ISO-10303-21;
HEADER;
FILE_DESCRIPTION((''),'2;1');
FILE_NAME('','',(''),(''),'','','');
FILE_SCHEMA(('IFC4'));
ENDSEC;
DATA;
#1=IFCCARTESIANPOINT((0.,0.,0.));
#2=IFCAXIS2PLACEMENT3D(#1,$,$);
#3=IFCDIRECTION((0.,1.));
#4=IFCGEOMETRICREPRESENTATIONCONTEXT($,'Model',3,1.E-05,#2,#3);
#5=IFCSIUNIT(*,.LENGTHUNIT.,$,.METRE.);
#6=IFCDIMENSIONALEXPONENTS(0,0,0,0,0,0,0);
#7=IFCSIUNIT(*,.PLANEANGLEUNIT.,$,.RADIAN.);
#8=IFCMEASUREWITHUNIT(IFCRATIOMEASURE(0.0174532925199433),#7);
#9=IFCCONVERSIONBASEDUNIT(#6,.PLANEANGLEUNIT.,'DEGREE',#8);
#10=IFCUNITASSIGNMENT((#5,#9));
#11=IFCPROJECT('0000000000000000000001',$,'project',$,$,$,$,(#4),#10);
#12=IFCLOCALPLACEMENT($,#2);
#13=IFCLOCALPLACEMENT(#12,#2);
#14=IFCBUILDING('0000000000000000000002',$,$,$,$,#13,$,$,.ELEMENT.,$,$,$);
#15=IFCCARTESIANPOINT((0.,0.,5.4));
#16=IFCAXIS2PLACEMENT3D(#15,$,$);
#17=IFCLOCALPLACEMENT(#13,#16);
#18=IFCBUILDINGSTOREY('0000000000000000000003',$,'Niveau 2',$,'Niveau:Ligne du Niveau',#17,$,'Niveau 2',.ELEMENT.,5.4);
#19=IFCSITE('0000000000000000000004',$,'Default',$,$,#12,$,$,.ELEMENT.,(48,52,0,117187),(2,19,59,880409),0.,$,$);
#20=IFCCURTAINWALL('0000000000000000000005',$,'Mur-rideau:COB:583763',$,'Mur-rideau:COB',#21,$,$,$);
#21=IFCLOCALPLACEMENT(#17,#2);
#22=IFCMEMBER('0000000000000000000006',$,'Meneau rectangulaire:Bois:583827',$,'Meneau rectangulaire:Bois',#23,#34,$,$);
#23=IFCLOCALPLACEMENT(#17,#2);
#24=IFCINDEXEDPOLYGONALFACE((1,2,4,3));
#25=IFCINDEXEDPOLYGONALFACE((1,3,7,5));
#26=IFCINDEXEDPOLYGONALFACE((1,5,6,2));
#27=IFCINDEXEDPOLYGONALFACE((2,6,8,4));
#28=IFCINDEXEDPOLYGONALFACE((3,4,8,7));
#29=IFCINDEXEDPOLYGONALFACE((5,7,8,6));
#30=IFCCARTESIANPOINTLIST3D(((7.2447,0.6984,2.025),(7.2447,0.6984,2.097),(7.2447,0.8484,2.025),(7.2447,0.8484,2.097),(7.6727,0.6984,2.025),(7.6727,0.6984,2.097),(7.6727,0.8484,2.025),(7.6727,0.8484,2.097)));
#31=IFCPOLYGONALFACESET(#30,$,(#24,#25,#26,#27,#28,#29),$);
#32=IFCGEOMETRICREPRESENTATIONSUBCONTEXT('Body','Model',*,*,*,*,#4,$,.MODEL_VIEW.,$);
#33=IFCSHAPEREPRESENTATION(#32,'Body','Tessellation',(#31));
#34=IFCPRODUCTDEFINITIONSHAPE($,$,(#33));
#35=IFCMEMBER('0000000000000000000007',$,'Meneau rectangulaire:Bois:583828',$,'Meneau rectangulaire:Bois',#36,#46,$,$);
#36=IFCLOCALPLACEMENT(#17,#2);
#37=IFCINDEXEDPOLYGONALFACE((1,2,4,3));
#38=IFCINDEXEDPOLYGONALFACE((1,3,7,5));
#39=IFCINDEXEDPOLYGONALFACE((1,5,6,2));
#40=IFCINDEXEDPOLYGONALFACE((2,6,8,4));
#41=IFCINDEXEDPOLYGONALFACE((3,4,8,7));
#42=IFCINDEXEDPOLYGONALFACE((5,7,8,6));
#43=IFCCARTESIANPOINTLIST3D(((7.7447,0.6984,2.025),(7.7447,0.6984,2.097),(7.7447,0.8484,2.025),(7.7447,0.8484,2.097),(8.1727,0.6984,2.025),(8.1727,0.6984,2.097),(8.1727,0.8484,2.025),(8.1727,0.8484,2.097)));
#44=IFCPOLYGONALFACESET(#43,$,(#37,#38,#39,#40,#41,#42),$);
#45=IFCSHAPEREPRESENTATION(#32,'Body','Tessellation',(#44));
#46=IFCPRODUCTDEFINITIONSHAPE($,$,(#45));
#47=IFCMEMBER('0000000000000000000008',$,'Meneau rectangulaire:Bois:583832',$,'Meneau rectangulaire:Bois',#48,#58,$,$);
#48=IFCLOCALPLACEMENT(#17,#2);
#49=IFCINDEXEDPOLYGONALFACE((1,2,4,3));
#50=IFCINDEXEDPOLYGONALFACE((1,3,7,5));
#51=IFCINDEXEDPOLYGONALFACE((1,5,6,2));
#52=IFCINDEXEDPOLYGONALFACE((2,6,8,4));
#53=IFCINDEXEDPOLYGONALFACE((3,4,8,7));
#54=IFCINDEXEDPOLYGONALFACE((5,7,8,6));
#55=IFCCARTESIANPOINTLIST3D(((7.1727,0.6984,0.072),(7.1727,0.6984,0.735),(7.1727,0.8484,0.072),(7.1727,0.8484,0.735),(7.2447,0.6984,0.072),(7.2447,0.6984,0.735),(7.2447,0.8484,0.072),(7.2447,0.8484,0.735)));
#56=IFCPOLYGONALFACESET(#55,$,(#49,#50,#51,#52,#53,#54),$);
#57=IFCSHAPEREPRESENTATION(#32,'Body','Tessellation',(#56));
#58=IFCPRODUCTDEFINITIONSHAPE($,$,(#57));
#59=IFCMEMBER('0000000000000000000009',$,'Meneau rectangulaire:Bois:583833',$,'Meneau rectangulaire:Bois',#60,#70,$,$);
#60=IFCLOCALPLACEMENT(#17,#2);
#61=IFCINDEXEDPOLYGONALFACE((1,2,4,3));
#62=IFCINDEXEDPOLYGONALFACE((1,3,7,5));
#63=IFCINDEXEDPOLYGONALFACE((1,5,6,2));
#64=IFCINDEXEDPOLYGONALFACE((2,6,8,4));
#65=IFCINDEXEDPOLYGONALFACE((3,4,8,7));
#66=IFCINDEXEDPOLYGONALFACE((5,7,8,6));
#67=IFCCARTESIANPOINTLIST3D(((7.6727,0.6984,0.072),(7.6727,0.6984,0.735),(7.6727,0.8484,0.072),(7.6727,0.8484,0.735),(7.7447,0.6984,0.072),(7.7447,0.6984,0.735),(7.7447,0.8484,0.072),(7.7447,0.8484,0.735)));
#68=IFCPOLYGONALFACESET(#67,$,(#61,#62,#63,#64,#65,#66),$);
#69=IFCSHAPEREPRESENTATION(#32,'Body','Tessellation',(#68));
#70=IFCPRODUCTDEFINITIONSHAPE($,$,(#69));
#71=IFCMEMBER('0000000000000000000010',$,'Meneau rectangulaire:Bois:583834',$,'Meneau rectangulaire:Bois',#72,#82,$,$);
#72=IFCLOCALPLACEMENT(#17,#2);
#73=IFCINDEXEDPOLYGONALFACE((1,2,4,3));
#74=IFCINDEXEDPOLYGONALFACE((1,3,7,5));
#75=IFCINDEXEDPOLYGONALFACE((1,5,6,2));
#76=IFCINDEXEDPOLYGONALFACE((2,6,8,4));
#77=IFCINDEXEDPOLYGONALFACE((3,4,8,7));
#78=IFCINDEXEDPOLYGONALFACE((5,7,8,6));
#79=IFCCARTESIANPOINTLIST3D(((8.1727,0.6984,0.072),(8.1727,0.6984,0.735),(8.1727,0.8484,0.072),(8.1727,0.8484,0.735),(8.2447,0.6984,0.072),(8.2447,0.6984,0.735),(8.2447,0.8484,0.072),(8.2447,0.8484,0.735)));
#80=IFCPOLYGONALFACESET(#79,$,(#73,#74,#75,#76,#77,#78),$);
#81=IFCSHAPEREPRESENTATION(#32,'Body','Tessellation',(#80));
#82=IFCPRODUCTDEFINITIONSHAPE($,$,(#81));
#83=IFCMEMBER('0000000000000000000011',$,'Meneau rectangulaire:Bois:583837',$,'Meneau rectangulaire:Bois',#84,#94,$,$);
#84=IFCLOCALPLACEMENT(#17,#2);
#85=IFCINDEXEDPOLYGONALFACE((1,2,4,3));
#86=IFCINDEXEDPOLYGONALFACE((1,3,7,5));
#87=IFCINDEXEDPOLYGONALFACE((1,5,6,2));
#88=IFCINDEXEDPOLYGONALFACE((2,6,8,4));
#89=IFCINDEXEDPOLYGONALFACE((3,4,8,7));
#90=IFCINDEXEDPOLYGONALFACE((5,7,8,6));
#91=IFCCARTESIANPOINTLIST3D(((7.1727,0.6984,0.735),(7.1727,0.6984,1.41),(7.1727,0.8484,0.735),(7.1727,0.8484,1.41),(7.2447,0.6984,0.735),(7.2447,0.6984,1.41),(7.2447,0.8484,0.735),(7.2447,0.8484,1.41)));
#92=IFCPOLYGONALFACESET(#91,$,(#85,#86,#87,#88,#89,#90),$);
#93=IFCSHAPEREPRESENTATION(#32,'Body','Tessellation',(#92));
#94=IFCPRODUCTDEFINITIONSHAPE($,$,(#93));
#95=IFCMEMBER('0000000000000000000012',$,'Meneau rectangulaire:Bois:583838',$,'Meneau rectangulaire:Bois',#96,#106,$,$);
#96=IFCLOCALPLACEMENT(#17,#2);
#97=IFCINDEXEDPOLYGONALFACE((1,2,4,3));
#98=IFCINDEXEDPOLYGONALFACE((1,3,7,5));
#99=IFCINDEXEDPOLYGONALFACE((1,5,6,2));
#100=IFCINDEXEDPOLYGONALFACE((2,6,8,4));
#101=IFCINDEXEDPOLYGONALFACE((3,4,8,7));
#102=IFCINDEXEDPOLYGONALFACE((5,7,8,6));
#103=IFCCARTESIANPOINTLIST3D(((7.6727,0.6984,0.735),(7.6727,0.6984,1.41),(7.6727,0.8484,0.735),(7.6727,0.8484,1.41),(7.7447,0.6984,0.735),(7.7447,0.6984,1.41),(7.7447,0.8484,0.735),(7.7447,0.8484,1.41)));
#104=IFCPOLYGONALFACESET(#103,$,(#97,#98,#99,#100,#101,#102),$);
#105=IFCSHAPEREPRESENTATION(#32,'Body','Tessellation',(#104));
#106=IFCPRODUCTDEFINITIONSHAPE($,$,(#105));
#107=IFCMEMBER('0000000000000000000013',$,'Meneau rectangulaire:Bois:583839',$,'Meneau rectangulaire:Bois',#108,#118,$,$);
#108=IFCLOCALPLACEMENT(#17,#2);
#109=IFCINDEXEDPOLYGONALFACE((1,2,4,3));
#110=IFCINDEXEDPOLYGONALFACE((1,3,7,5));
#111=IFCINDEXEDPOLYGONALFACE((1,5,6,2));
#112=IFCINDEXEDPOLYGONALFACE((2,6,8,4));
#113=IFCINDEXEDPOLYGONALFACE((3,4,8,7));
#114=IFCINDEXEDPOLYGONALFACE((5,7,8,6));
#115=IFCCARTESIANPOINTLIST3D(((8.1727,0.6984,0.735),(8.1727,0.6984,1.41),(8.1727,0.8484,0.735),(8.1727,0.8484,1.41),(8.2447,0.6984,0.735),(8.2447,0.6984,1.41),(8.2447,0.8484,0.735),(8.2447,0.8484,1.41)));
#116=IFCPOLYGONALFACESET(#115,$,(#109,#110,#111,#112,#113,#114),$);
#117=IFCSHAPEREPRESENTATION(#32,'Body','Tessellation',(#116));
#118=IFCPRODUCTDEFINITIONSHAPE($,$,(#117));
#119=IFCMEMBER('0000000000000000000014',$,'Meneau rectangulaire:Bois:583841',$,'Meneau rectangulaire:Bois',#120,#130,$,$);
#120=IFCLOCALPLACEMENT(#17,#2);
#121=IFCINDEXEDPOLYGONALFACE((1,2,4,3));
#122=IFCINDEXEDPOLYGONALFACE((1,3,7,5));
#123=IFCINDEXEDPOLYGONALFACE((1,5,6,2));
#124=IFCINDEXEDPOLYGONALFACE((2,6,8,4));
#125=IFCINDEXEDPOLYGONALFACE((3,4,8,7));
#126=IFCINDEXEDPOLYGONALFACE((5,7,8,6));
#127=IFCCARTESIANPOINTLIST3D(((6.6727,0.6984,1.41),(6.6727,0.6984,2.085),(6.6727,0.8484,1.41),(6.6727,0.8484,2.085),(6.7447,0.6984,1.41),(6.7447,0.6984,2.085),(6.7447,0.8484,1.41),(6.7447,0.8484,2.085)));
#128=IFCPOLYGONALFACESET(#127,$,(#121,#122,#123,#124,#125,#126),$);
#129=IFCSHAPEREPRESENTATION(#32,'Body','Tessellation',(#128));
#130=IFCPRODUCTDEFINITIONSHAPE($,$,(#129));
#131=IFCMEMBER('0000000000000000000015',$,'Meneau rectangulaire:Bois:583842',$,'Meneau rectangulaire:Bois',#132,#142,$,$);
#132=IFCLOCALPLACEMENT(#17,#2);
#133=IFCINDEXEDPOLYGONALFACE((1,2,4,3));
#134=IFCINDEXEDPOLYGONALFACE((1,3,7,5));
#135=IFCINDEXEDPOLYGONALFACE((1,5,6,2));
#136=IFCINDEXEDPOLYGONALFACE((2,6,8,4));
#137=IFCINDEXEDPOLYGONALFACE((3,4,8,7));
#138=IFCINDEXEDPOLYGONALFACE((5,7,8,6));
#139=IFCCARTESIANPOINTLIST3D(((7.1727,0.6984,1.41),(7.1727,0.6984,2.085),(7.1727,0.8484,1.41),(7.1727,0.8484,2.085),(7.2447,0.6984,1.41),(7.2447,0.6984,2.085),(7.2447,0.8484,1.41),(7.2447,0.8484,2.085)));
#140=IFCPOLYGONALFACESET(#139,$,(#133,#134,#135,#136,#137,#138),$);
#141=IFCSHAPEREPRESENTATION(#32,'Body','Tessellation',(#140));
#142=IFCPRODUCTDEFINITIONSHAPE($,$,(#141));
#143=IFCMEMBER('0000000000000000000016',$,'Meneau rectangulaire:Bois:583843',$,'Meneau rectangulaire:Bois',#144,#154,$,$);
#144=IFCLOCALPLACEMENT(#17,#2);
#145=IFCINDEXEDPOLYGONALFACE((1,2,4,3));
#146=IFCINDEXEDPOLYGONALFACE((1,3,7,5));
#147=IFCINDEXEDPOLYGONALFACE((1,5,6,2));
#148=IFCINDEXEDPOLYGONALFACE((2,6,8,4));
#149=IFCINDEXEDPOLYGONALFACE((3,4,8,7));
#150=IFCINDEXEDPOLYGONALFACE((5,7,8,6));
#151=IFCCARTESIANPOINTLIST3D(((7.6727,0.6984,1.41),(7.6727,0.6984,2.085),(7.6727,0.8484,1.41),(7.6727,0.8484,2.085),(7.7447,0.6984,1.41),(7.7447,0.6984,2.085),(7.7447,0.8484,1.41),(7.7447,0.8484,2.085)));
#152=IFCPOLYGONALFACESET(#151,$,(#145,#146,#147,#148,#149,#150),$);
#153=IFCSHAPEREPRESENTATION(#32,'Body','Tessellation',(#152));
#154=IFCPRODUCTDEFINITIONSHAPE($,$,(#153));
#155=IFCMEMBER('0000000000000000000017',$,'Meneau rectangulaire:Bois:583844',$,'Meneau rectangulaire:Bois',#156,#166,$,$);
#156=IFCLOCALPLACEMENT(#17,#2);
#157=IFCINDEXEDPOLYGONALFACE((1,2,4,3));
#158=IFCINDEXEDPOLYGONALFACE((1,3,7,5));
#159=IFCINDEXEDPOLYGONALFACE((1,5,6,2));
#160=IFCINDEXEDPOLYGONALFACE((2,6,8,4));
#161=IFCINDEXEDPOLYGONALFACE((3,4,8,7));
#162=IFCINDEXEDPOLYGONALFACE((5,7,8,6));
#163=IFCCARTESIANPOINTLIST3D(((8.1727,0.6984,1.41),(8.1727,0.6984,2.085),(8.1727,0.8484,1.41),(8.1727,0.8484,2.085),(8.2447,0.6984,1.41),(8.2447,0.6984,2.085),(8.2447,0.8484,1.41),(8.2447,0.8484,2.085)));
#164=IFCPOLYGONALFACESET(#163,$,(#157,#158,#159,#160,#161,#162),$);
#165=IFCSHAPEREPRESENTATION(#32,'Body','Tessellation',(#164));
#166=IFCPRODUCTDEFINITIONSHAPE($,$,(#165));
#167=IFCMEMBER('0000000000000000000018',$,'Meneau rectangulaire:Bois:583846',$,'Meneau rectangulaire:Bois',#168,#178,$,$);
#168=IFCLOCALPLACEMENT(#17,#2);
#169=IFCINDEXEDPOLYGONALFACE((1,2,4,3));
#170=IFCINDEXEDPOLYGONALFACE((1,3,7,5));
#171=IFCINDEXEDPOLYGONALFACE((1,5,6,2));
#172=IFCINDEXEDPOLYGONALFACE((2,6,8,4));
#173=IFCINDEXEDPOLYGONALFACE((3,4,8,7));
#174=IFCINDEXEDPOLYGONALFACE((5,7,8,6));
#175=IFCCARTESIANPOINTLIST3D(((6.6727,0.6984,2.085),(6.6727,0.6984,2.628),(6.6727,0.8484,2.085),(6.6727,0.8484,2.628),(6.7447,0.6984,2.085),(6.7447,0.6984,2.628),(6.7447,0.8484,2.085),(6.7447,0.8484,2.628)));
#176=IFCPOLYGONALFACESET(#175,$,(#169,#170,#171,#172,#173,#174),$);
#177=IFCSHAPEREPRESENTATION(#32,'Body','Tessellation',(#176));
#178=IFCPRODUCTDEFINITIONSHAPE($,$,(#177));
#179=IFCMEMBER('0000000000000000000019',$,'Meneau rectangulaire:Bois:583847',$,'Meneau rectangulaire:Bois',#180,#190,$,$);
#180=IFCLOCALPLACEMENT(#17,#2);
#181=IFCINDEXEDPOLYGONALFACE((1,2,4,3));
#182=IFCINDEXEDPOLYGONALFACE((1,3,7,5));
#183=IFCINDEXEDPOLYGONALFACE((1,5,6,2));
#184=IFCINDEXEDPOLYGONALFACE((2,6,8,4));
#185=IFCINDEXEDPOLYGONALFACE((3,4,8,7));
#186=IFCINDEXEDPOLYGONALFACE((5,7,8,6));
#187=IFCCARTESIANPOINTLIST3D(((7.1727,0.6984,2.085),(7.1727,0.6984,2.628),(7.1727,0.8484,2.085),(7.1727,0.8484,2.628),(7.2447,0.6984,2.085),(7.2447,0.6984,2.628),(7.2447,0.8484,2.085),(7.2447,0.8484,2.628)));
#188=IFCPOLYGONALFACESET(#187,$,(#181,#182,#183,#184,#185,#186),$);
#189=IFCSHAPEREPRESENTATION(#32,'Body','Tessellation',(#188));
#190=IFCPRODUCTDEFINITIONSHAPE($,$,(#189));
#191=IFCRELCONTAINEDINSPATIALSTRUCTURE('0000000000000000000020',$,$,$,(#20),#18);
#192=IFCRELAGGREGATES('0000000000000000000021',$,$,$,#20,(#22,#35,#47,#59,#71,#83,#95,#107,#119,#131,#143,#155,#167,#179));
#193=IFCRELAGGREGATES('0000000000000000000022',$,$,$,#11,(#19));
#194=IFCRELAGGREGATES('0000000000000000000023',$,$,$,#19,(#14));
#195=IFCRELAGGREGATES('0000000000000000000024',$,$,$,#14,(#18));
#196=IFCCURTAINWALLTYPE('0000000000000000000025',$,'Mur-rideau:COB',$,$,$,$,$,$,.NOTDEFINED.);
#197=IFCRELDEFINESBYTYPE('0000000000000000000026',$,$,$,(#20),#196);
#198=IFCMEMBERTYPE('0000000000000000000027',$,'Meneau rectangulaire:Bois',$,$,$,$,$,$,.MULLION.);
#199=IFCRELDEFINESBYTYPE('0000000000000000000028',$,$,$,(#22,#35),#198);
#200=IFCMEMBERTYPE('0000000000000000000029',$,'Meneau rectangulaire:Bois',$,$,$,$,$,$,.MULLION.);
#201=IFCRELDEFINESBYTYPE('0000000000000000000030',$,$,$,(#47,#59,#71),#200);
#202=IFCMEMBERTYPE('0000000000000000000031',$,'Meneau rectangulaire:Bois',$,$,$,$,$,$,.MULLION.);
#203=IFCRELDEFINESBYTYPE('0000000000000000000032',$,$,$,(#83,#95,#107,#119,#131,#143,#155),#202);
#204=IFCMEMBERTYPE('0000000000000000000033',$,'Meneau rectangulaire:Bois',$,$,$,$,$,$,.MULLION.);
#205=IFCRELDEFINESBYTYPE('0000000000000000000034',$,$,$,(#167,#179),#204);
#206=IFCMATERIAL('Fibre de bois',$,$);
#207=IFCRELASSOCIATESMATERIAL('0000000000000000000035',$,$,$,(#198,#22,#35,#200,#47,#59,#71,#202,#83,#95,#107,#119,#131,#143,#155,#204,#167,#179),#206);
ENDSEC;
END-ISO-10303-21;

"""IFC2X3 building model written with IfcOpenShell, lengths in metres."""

from ifc_helpers import new_model, entity, si_unit, converted_unit, direction, frame, origin, origin_2d_with_axis, place, context, subcontext, project, spatial, rectangle, extrude, source, transform, mapped, material, type_object, type_shapes, element, aggregate, save


model = new_model("IFC2X3")

# Units and contexts
model_context = context("Model", 3, precision=1e-05, world=origin(), true_north=direction((0.0, 1.0)))
body_context = subcontext(model_context, "Body", "Model", "MODEL_VIEW")
ifc_project = project(units=[si_unit("LENGTHUNIT", "METRE"), converted_unit("PLANEANGLEUNIT", "DEGREE", entity("IfcRatioMeasure", 0.0174532925199433), si_unit("PLANEANGLEUNIT", "RADIAN"), dimensions=[0, 0, 0, 0, 0, 0, 0])], contexts=[model_context])

# Site, building, storey
site_placement = place(None, origin())
site = spatial("IfcSite", under=ifc_project, at=site_placement, Name="Default", CompositionType="ELEMENT", RefLatitude=(48, 52, 0, 117187), RefLongitude=(2, 19, 59, 880409), RefElevation=0.0)
building_placement = place(site_placement, origin())
building = spatial("IfcBuilding", under=site, at=building_placement, CompositionType="ELEMENT")
storey_placement = place(building_placement, frame((0.0, 0.0, 5.4)))
storey = spatial("IfcBuildingStorey", under=building, at=storey_placement, Name="Niveau 2", ObjectType="Niveau:Ligne du Niveau", LongName="Niveau 2", CompositionType="ELEMENT", Elevation=5.4)

# Curtain wall, members
curtain_wall_type_1 = type_object("IfcCurtainWallType", Name="Mur-rideau:COB", PredefinedType="NOTDEFINED")
curtain_wall_1_placement = place(storey_placement, frame((0.0, 0.0, -5.4)))
curtain_wall_1 = element("IfcCurtainWall", 1, at=curtain_wall_1_placement, inside=storey, type_object=curtain_wall_type_1, Name="Mur-rideau:COB:583763", ObjectType="Mur-rideau:COB")
ifc_material_1 = material(Name="Fibre de bois")
member_type_1 = type_object("IfcMemberType", Name="Meneau rectangulaire:Bois", PredefinedType="MULLION", material=ifc_material_1)
shared_shape_1 = source(origin(), body_context, "Body", "SweptSolid", [
    extrude(rectangle(XDim=0.15, YDim=0.072, at=origin_2d_with_axis()), frame((-0.024, 0.0, -0.428), z_axis=(0.0, 0.0, 1.0), x_axis=(0.0, -1.0, 0.0)), (0.0, 0.0, 1.0), 0.428),
])
type_shapes(member_type_1, [shared_shape_1])
member_1_placement = place(storey_placement, frame((7.6727, 0.7734, 2.085), z_axis=(1.0, 0.0, 0.0), x_axis=(0.0, 0.0, 1.0)))
member_1 = element("IfcMember", 2, at=member_1_placement, type_object=member_type_1, material=ifc_material_1, Name="Meneau rectangulaire:Bois:583827", ObjectType="Meneau rectangulaire:Bois", context=body_context, shape_type="MappedRepresentation", body=[
    mapped(shared_shape_1, transform((0.0, 0.0, 0.0), scale=1.0)),
])
member_2_placement = place(storey_placement, frame((8.1727, 0.7734, 2.085), z_axis=(1.0, 0.0, 0.0), x_axis=(0.0, 0.0, 1.0)))
member_2 = element("IfcMember", 3, at=member_2_placement, type_object=member_type_1, material=ifc_material_1, Name="Meneau rectangulaire:Bois:583828", ObjectType="Meneau rectangulaire:Bois", context=body_context, shape_type="MappedRepresentation", body=[
    mapped(shared_shape_1, transform((0.0, 0.0, 0.0), scale=1.0)),
])
member_type_2 = type_object("IfcMemberType", Name="Meneau rectangulaire:Bois", PredefinedType="MULLION", material=ifc_material_1)
shared_shape_2 = source(origin(), body_context, "Body", "SweptSolid", [
    extrude(rectangle(XDim=0.15, YDim=0.072, at=origin_2d_with_axis()), frame((-0.024, 0.0, -0.663), z_axis=(0.0, 0.0, 1.0), x_axis=(0.0, -1.0, 0.0)), (0.0, 0.0, 1.0), 0.663),
])
type_shapes(member_type_2, [shared_shape_2])
member_3_placement = place(storey_placement, frame((7.2327, 0.7734, 0.072), z_axis=(0.0, 0.0, -1.0), x_axis=(1.0, 0.0, 0.0)))
member_3 = element("IfcMember", 4, at=member_3_placement, type_object=member_type_2, material=ifc_material_1, Name="Meneau rectangulaire:Bois:583832", ObjectType="Meneau rectangulaire:Bois", context=body_context, shape_type="MappedRepresentation", body=[
    mapped(shared_shape_2, transform((0.0, 0.0, 0.0), scale=1.0)),
])
member_4_placement = place(storey_placement, frame((7.7327, 0.7734, 0.072), z_axis=(0.0, 0.0, -1.0), x_axis=(1.0, 0.0, 0.0)))
member_4 = element("IfcMember", 5, at=member_4_placement, type_object=member_type_2, material=ifc_material_1, Name="Meneau rectangulaire:Bois:583833", ObjectType="Meneau rectangulaire:Bois", context=body_context, shape_type="MappedRepresentation", body=[
    mapped(shared_shape_2, transform((0.0, 0.0, 0.0), scale=1.0)),
])
member_5_placement = place(storey_placement, frame((8.2327, 0.7734, 0.072), z_axis=(0.0, 0.0, -1.0), x_axis=(1.0, 0.0, 0.0)))
member_5 = element("IfcMember", 6, at=member_5_placement, type_object=member_type_2, material=ifc_material_1, Name="Meneau rectangulaire:Bois:583834", ObjectType="Meneau rectangulaire:Bois", context=body_context, shape_type="MappedRepresentation", body=[
    mapped(shared_shape_2, transform((0.0, 0.0, 0.0), scale=1.0)),
])
member_type_3 = type_object("IfcMemberType", Name="Meneau rectangulaire:Bois", PredefinedType="MULLION", material=ifc_material_1)
shared_shape_3 = source(origin(), body_context, "Body", "SweptSolid", [
    extrude(rectangle(XDim=0.15, YDim=0.072, at=origin_2d_with_axis()), frame((-0.024, 0.0, -0.675), z_axis=(0.0, 0.0, 1.0), x_axis=(0.0, -1.0, 0.0)), (0.0, 0.0, 1.0), 0.675),
])
type_shapes(member_type_3, [shared_shape_3])
member_6_placement = place(storey_placement, frame((7.2327, 0.7734, 0.735), z_axis=(0.0, 0.0, -1.0), x_axis=(1.0, 0.0, 0.0)))
member_6 = element("IfcMember", 7, at=member_6_placement, type_object=member_type_3, material=ifc_material_1, Name="Meneau rectangulaire:Bois:583837", ObjectType="Meneau rectangulaire:Bois", context=body_context, shape_type="MappedRepresentation", body=[
    mapped(shared_shape_3, transform((0.0, 0.0, 0.0), scale=1.0)),
])
member_7_placement = place(storey_placement, frame((7.7327, 0.7734, 0.735), z_axis=(0.0, 0.0, -1.0), x_axis=(1.0, 0.0, 0.0)))
member_7 = element("IfcMember", 8, at=member_7_placement, type_object=member_type_3, material=ifc_material_1, Name="Meneau rectangulaire:Bois:583838", ObjectType="Meneau rectangulaire:Bois", context=body_context, shape_type="MappedRepresentation", body=[
    mapped(shared_shape_3, transform((0.0, 0.0, 0.0), scale=1.0)),
])
member_8_placement = place(storey_placement, frame((8.2327, 0.7734, 0.735), z_axis=(0.0, 0.0, -1.0), x_axis=(1.0, 0.0, 0.0)))
member_8 = element("IfcMember", 9, at=member_8_placement, type_object=member_type_3, material=ifc_material_1, Name="Meneau rectangulaire:Bois:583839", ObjectType="Meneau rectangulaire:Bois", context=body_context, shape_type="MappedRepresentation", body=[
    mapped(shared_shape_3, transform((0.0, 0.0, 0.0), scale=1.0)),
])
member_9_placement = place(storey_placement, frame((6.7327, 0.7734, 1.41), z_axis=(0.0, 0.0, -1.0), x_axis=(1.0, 0.0, 0.0)))
member_9 = element("IfcMember", 10, at=member_9_placement, type_object=member_type_3, material=ifc_material_1, Name="Meneau rectangulaire:Bois:583841", ObjectType="Meneau rectangulaire:Bois", context=body_context, shape_type="MappedRepresentation", body=[
    mapped(shared_shape_3, transform((0.0, 0.0, 0.0), scale=1.0)),
])
member_10_placement = place(storey_placement, frame((7.2327, 0.7734, 1.41), z_axis=(0.0, 0.0, -1.0), x_axis=(1.0, 0.0, 0.0)))
member_10 = element("IfcMember", 11, at=member_10_placement, type_object=member_type_3, material=ifc_material_1, Name="Meneau rectangulaire:Bois:583842", ObjectType="Meneau rectangulaire:Bois", context=body_context, shape_type="MappedRepresentation", body=[
    mapped(shared_shape_3, transform((0.0, 0.0, 0.0), scale=1.0)),
])
member_11_placement = place(storey_placement, frame((7.7327, 0.7734, 1.41), z_axis=(0.0, 0.0, -1.0), x_axis=(1.0, 0.0, 0.0)))
member_11 = element("IfcMember", 12, at=member_11_placement, type_object=member_type_3, material=ifc_material_1, Name="Meneau rectangulaire:Bois:583843", ObjectType="Meneau rectangulaire:Bois", context=body_context, shape_type="MappedRepresentation", body=[
    mapped(shared_shape_3, transform((0.0, 0.0, 0.0), scale=1.0)),
])
member_12_placement = place(storey_placement, frame((8.2327, 0.7734, 1.41), z_axis=(0.0, 0.0, -1.0), x_axis=(1.0, 0.0, 0.0)))
member_12 = element("IfcMember", 13, at=member_12_placement, type_object=member_type_3, material=ifc_material_1, Name="Meneau rectangulaire:Bois:583844", ObjectType="Meneau rectangulaire:Bois", context=body_context, shape_type="MappedRepresentation", body=[
    mapped(shared_shape_3, transform((0.0, 0.0, 0.0), scale=1.0)),
])
member_type_4 = type_object("IfcMemberType", Name="Meneau rectangulaire:Bois", PredefinedType="MULLION", material=ifc_material_1)
shared_shape_4 = source(origin(), body_context, "Body", "SweptSolid", [
    extrude(rectangle(XDim=0.15, YDim=0.072, at=origin_2d_with_axis()), frame((-0.024, 0.0, -0.543), z_axis=(0.0, 0.0, 1.0), x_axis=(0.0, -1.0, 0.0)), (0.0, 0.0, 1.0), 0.543),
])
type_shapes(member_type_4, [shared_shape_4])
member_13_placement = place(storey_placement, frame((6.7327, 0.7734, 2.085), z_axis=(0.0, 0.0, -1.0), x_axis=(1.0, 0.0, 0.0)))
member_13 = element("IfcMember", 14, at=member_13_placement, type_object=member_type_4, material=ifc_material_1, Name="Meneau rectangulaire:Bois:583846", ObjectType="Meneau rectangulaire:Bois", context=body_context, shape_type="MappedRepresentation", body=[
    mapped(shared_shape_4, transform((0.0, 0.0, 0.0), scale=1.0)),
])
member_14_placement = place(storey_placement, frame((7.2327, 0.7734, 2.085), z_axis=(0.0, 0.0, -1.0), x_axis=(1.0, 0.0, 0.0)))
member_14 = element("IfcMember", 15, at=member_14_placement, type_object=member_type_4, material=ifc_material_1, Name="Meneau rectangulaire:Bois:583847", ObjectType="Meneau rectangulaire:Bois", context=body_context, shape_type="MappedRepresentation", body=[
    mapped(shared_shape_4, transform((0.0, 0.0, 0.0), scale=1.0)),
])
aggregate(curtain_wall_1, [member_1, member_2, member_3, member_4, member_5, member_6, member_7, member_8, member_9, member_10, member_11, member_12, member_13, member_14])

save(model, "model.ifc")
